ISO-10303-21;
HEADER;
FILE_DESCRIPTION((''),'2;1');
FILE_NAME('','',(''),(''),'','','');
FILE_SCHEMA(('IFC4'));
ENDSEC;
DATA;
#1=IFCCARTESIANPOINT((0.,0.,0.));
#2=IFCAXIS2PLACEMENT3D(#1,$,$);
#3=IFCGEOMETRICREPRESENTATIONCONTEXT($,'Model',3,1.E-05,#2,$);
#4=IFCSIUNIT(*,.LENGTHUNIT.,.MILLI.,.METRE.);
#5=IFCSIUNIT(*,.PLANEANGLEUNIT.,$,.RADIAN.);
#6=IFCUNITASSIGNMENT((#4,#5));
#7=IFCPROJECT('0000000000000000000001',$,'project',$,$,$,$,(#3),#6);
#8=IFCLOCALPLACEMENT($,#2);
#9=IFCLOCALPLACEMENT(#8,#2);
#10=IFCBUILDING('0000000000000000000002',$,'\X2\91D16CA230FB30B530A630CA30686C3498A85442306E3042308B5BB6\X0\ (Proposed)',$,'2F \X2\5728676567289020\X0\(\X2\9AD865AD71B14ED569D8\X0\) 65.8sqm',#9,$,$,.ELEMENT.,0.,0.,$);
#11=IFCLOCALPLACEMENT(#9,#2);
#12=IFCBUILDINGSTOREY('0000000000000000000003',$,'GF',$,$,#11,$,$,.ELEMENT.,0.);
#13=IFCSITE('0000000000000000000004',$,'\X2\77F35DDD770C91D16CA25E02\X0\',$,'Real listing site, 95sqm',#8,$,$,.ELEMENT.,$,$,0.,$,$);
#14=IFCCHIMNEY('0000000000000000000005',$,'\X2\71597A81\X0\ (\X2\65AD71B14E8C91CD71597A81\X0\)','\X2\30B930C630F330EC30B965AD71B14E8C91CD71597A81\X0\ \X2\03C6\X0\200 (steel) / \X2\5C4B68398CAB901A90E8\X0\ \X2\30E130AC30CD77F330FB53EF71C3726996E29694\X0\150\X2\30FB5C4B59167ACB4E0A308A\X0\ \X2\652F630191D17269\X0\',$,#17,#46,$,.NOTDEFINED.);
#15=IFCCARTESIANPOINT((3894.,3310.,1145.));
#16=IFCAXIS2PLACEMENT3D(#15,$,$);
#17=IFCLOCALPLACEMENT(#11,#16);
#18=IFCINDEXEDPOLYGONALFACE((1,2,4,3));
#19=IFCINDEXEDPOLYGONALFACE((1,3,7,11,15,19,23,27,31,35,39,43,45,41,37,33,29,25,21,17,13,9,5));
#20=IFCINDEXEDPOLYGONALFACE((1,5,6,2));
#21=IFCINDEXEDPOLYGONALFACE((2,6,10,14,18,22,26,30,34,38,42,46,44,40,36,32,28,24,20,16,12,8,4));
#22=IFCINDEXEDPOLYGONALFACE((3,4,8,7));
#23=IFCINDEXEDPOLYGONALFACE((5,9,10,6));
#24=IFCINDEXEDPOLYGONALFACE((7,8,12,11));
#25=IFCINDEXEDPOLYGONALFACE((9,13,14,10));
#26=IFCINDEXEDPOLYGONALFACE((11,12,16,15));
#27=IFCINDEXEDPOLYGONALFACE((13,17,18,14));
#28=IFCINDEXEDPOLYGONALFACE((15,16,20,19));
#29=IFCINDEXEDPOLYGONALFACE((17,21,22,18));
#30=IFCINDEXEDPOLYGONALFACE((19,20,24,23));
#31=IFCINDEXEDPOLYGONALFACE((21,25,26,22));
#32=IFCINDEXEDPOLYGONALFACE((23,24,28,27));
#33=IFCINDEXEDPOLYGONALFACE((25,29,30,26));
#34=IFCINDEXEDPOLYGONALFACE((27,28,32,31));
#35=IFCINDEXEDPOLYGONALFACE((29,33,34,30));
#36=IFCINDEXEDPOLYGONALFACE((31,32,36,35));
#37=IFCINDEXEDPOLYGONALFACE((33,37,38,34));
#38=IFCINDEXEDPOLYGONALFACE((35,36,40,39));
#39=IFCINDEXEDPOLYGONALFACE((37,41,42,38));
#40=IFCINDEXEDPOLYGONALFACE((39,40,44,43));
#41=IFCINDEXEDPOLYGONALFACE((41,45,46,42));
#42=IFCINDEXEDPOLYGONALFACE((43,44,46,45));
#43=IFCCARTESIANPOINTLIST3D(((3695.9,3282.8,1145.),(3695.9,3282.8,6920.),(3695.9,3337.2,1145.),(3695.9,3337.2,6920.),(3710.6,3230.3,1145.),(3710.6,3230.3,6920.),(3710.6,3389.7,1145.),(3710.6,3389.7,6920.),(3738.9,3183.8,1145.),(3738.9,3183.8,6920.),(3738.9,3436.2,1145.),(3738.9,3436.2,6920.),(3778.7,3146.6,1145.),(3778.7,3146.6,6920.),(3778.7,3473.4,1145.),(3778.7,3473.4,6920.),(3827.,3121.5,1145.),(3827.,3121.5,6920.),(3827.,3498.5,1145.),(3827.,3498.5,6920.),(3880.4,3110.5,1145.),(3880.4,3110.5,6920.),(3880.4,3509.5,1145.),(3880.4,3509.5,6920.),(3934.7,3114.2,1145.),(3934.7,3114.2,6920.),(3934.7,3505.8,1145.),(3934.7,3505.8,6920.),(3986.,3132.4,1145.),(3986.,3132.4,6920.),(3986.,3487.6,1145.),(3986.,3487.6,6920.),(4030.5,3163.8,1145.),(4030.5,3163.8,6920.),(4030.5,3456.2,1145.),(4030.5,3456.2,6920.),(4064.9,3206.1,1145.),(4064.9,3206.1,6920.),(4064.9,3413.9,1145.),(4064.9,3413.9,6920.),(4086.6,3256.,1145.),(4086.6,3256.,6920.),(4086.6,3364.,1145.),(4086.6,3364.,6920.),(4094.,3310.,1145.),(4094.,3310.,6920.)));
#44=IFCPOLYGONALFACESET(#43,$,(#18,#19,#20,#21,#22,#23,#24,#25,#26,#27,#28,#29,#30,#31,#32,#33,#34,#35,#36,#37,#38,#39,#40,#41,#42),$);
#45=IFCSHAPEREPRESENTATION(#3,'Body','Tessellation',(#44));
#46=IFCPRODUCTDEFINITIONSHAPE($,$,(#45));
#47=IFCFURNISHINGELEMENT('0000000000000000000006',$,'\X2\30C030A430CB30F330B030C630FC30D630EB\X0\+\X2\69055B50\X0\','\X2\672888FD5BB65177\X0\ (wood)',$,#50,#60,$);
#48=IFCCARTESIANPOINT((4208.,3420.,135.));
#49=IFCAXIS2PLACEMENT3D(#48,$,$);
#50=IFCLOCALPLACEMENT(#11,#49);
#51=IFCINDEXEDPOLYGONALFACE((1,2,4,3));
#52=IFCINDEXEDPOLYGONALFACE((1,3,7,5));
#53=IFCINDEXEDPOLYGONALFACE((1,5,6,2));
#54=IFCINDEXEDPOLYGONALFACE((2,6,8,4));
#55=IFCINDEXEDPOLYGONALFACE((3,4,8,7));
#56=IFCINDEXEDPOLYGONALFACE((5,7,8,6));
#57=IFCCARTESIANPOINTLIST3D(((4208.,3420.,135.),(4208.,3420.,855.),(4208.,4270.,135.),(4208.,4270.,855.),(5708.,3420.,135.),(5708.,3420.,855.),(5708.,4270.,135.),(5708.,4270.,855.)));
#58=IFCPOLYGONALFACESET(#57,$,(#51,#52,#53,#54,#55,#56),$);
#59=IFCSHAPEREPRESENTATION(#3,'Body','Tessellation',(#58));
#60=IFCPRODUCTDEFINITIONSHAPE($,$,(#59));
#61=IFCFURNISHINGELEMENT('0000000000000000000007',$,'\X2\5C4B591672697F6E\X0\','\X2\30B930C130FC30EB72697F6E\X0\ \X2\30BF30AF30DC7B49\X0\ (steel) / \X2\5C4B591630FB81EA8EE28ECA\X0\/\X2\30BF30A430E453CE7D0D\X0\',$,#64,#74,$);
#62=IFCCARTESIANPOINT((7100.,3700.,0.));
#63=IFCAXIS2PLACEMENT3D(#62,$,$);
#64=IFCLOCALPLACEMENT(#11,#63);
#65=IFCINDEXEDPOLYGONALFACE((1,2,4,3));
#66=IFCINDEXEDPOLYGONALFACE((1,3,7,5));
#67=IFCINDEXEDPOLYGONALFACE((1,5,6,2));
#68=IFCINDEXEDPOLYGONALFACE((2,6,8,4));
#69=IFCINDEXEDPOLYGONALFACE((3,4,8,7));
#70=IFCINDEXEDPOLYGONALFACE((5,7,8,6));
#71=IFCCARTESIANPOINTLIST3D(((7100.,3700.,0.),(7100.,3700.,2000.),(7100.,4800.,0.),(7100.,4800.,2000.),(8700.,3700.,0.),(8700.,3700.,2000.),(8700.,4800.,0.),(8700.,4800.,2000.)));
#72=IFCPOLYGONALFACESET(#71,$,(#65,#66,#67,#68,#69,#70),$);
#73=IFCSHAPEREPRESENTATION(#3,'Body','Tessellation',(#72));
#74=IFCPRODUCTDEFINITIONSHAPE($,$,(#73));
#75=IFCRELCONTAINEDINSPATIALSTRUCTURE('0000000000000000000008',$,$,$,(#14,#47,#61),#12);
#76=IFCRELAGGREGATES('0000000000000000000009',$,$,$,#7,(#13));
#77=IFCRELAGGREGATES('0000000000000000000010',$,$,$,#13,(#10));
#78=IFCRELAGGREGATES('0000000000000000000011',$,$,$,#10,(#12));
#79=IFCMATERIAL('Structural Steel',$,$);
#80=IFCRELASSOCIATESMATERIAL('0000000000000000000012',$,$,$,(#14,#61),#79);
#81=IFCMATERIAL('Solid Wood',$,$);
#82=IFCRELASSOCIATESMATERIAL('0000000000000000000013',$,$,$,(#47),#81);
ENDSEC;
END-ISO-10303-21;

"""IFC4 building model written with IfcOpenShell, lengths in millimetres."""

from ifc_helpers import new_model, si_unit, frame, frame_2d, origin, origin_2d, place, context, project, spatial, rectangle, circle, extrude, material, element, save


model = new_model("IFC4")

# Units and contexts
model_context = context("Model", 3, precision=1e-05, world=origin())
ifc_project = project(units=[si_unit("LENGTHUNIT", "METRE", prefix="MILLI"), si_unit("PLANEANGLEUNIT", "RADIAN")], contexts=[model_context])

# Site, building, storey
site_placement = place(None, origin())
site = spatial("IfcSite", under=ifc_project, at=site_placement, Name="石川県金沢市", ObjectType="Real listing site, 95sqm", CompositionType="ELEMENT", RefElevation=0.0)
building_placement = place(site_placement, origin())
building = spatial("IfcBuilding", under=site, at=building_placement, Name="金沢・サウナと水風呂のある家 (Proposed)", ObjectType="2F 在来木造(高断熱仕様) 65.8sqm", CompositionType="ELEMENT", ElevationOfRefHeight=0.0, ElevationOfTerrain=0.0)
storey_placement = place(building_placement, origin())
storey = spatial("IfcBuildingStorey", under=building, at=storey_placement, Name="GF", CompositionType="ELEMENT", Elevation=0.0)

# Shared definitions
ifc_material_1 = material(Name="Solid Wood")

# Shared definitions
ifc_material_2 = material(Name="Structural Steel")

# Chimney
chimney_placement = place(storey_placement, frame((3894.0, 3310.0, 1145.0)))
element("IfcChimney", 1, at=chimney_placement, inside=storey, material=ifc_material_2, Name="煙突 (断熱二重煙突)", Description="ステンレス断熱二重煙突 φ200 (steel) / 屋根貫通部 メガネ石・可燃物離隔150・屋外立上り 支持金物", PredefinedType="NOTDEFINED", context=model_context, shape_type="SweptSolid", body=[
    extrude(circle(Radius=200.0, at=origin_2d()), frame((3894.0, 3310.0, 1145.0)), (0.0, 0.0, 1.0), 5775.0),
])

# Furnishing elements
furnishing_1_placement = place(storey_placement, frame((4208.0, 3420.0, 135.0)))
element("IfcFurnishingElement", 2, at=furnishing_1_placement, inside=storey, material=ifc_material_1, Name="ダイニングテーブル+椅子", Description="木製家具 (wood)", context=model_context, shape_type="SweptSolid", body=[
    extrude(rectangle(XDim=1500.0, YDim=850.0, at=frame_2d((750.0, 425.0))), frame((4208.0, 3420.0, 135.0)), (0.0, 0.0, 1.0), 720.0),
])
furnishing_2_placement = place(storey_placement, frame((7100.0, 3700.0, 0.0)))
element("IfcFurnishingElement", 3, at=furnishing_2_placement, inside=storey, material=ifc_material_2, Name="屋外物置", Description="スチール物置 タクボ等 (steel) / 屋外・自転車/タイヤ収納", context=model_context, shape_type="SweptSolid", body=[
    extrude(rectangle(XDim=1600.0, YDim=1100.0, at=frame_2d((800.0, 550.0))), frame((7100.0, 3700.0, 0.0)), (0.0, 0.0, 1.0), 2000.0),
])

save(model, "model.ifc")
